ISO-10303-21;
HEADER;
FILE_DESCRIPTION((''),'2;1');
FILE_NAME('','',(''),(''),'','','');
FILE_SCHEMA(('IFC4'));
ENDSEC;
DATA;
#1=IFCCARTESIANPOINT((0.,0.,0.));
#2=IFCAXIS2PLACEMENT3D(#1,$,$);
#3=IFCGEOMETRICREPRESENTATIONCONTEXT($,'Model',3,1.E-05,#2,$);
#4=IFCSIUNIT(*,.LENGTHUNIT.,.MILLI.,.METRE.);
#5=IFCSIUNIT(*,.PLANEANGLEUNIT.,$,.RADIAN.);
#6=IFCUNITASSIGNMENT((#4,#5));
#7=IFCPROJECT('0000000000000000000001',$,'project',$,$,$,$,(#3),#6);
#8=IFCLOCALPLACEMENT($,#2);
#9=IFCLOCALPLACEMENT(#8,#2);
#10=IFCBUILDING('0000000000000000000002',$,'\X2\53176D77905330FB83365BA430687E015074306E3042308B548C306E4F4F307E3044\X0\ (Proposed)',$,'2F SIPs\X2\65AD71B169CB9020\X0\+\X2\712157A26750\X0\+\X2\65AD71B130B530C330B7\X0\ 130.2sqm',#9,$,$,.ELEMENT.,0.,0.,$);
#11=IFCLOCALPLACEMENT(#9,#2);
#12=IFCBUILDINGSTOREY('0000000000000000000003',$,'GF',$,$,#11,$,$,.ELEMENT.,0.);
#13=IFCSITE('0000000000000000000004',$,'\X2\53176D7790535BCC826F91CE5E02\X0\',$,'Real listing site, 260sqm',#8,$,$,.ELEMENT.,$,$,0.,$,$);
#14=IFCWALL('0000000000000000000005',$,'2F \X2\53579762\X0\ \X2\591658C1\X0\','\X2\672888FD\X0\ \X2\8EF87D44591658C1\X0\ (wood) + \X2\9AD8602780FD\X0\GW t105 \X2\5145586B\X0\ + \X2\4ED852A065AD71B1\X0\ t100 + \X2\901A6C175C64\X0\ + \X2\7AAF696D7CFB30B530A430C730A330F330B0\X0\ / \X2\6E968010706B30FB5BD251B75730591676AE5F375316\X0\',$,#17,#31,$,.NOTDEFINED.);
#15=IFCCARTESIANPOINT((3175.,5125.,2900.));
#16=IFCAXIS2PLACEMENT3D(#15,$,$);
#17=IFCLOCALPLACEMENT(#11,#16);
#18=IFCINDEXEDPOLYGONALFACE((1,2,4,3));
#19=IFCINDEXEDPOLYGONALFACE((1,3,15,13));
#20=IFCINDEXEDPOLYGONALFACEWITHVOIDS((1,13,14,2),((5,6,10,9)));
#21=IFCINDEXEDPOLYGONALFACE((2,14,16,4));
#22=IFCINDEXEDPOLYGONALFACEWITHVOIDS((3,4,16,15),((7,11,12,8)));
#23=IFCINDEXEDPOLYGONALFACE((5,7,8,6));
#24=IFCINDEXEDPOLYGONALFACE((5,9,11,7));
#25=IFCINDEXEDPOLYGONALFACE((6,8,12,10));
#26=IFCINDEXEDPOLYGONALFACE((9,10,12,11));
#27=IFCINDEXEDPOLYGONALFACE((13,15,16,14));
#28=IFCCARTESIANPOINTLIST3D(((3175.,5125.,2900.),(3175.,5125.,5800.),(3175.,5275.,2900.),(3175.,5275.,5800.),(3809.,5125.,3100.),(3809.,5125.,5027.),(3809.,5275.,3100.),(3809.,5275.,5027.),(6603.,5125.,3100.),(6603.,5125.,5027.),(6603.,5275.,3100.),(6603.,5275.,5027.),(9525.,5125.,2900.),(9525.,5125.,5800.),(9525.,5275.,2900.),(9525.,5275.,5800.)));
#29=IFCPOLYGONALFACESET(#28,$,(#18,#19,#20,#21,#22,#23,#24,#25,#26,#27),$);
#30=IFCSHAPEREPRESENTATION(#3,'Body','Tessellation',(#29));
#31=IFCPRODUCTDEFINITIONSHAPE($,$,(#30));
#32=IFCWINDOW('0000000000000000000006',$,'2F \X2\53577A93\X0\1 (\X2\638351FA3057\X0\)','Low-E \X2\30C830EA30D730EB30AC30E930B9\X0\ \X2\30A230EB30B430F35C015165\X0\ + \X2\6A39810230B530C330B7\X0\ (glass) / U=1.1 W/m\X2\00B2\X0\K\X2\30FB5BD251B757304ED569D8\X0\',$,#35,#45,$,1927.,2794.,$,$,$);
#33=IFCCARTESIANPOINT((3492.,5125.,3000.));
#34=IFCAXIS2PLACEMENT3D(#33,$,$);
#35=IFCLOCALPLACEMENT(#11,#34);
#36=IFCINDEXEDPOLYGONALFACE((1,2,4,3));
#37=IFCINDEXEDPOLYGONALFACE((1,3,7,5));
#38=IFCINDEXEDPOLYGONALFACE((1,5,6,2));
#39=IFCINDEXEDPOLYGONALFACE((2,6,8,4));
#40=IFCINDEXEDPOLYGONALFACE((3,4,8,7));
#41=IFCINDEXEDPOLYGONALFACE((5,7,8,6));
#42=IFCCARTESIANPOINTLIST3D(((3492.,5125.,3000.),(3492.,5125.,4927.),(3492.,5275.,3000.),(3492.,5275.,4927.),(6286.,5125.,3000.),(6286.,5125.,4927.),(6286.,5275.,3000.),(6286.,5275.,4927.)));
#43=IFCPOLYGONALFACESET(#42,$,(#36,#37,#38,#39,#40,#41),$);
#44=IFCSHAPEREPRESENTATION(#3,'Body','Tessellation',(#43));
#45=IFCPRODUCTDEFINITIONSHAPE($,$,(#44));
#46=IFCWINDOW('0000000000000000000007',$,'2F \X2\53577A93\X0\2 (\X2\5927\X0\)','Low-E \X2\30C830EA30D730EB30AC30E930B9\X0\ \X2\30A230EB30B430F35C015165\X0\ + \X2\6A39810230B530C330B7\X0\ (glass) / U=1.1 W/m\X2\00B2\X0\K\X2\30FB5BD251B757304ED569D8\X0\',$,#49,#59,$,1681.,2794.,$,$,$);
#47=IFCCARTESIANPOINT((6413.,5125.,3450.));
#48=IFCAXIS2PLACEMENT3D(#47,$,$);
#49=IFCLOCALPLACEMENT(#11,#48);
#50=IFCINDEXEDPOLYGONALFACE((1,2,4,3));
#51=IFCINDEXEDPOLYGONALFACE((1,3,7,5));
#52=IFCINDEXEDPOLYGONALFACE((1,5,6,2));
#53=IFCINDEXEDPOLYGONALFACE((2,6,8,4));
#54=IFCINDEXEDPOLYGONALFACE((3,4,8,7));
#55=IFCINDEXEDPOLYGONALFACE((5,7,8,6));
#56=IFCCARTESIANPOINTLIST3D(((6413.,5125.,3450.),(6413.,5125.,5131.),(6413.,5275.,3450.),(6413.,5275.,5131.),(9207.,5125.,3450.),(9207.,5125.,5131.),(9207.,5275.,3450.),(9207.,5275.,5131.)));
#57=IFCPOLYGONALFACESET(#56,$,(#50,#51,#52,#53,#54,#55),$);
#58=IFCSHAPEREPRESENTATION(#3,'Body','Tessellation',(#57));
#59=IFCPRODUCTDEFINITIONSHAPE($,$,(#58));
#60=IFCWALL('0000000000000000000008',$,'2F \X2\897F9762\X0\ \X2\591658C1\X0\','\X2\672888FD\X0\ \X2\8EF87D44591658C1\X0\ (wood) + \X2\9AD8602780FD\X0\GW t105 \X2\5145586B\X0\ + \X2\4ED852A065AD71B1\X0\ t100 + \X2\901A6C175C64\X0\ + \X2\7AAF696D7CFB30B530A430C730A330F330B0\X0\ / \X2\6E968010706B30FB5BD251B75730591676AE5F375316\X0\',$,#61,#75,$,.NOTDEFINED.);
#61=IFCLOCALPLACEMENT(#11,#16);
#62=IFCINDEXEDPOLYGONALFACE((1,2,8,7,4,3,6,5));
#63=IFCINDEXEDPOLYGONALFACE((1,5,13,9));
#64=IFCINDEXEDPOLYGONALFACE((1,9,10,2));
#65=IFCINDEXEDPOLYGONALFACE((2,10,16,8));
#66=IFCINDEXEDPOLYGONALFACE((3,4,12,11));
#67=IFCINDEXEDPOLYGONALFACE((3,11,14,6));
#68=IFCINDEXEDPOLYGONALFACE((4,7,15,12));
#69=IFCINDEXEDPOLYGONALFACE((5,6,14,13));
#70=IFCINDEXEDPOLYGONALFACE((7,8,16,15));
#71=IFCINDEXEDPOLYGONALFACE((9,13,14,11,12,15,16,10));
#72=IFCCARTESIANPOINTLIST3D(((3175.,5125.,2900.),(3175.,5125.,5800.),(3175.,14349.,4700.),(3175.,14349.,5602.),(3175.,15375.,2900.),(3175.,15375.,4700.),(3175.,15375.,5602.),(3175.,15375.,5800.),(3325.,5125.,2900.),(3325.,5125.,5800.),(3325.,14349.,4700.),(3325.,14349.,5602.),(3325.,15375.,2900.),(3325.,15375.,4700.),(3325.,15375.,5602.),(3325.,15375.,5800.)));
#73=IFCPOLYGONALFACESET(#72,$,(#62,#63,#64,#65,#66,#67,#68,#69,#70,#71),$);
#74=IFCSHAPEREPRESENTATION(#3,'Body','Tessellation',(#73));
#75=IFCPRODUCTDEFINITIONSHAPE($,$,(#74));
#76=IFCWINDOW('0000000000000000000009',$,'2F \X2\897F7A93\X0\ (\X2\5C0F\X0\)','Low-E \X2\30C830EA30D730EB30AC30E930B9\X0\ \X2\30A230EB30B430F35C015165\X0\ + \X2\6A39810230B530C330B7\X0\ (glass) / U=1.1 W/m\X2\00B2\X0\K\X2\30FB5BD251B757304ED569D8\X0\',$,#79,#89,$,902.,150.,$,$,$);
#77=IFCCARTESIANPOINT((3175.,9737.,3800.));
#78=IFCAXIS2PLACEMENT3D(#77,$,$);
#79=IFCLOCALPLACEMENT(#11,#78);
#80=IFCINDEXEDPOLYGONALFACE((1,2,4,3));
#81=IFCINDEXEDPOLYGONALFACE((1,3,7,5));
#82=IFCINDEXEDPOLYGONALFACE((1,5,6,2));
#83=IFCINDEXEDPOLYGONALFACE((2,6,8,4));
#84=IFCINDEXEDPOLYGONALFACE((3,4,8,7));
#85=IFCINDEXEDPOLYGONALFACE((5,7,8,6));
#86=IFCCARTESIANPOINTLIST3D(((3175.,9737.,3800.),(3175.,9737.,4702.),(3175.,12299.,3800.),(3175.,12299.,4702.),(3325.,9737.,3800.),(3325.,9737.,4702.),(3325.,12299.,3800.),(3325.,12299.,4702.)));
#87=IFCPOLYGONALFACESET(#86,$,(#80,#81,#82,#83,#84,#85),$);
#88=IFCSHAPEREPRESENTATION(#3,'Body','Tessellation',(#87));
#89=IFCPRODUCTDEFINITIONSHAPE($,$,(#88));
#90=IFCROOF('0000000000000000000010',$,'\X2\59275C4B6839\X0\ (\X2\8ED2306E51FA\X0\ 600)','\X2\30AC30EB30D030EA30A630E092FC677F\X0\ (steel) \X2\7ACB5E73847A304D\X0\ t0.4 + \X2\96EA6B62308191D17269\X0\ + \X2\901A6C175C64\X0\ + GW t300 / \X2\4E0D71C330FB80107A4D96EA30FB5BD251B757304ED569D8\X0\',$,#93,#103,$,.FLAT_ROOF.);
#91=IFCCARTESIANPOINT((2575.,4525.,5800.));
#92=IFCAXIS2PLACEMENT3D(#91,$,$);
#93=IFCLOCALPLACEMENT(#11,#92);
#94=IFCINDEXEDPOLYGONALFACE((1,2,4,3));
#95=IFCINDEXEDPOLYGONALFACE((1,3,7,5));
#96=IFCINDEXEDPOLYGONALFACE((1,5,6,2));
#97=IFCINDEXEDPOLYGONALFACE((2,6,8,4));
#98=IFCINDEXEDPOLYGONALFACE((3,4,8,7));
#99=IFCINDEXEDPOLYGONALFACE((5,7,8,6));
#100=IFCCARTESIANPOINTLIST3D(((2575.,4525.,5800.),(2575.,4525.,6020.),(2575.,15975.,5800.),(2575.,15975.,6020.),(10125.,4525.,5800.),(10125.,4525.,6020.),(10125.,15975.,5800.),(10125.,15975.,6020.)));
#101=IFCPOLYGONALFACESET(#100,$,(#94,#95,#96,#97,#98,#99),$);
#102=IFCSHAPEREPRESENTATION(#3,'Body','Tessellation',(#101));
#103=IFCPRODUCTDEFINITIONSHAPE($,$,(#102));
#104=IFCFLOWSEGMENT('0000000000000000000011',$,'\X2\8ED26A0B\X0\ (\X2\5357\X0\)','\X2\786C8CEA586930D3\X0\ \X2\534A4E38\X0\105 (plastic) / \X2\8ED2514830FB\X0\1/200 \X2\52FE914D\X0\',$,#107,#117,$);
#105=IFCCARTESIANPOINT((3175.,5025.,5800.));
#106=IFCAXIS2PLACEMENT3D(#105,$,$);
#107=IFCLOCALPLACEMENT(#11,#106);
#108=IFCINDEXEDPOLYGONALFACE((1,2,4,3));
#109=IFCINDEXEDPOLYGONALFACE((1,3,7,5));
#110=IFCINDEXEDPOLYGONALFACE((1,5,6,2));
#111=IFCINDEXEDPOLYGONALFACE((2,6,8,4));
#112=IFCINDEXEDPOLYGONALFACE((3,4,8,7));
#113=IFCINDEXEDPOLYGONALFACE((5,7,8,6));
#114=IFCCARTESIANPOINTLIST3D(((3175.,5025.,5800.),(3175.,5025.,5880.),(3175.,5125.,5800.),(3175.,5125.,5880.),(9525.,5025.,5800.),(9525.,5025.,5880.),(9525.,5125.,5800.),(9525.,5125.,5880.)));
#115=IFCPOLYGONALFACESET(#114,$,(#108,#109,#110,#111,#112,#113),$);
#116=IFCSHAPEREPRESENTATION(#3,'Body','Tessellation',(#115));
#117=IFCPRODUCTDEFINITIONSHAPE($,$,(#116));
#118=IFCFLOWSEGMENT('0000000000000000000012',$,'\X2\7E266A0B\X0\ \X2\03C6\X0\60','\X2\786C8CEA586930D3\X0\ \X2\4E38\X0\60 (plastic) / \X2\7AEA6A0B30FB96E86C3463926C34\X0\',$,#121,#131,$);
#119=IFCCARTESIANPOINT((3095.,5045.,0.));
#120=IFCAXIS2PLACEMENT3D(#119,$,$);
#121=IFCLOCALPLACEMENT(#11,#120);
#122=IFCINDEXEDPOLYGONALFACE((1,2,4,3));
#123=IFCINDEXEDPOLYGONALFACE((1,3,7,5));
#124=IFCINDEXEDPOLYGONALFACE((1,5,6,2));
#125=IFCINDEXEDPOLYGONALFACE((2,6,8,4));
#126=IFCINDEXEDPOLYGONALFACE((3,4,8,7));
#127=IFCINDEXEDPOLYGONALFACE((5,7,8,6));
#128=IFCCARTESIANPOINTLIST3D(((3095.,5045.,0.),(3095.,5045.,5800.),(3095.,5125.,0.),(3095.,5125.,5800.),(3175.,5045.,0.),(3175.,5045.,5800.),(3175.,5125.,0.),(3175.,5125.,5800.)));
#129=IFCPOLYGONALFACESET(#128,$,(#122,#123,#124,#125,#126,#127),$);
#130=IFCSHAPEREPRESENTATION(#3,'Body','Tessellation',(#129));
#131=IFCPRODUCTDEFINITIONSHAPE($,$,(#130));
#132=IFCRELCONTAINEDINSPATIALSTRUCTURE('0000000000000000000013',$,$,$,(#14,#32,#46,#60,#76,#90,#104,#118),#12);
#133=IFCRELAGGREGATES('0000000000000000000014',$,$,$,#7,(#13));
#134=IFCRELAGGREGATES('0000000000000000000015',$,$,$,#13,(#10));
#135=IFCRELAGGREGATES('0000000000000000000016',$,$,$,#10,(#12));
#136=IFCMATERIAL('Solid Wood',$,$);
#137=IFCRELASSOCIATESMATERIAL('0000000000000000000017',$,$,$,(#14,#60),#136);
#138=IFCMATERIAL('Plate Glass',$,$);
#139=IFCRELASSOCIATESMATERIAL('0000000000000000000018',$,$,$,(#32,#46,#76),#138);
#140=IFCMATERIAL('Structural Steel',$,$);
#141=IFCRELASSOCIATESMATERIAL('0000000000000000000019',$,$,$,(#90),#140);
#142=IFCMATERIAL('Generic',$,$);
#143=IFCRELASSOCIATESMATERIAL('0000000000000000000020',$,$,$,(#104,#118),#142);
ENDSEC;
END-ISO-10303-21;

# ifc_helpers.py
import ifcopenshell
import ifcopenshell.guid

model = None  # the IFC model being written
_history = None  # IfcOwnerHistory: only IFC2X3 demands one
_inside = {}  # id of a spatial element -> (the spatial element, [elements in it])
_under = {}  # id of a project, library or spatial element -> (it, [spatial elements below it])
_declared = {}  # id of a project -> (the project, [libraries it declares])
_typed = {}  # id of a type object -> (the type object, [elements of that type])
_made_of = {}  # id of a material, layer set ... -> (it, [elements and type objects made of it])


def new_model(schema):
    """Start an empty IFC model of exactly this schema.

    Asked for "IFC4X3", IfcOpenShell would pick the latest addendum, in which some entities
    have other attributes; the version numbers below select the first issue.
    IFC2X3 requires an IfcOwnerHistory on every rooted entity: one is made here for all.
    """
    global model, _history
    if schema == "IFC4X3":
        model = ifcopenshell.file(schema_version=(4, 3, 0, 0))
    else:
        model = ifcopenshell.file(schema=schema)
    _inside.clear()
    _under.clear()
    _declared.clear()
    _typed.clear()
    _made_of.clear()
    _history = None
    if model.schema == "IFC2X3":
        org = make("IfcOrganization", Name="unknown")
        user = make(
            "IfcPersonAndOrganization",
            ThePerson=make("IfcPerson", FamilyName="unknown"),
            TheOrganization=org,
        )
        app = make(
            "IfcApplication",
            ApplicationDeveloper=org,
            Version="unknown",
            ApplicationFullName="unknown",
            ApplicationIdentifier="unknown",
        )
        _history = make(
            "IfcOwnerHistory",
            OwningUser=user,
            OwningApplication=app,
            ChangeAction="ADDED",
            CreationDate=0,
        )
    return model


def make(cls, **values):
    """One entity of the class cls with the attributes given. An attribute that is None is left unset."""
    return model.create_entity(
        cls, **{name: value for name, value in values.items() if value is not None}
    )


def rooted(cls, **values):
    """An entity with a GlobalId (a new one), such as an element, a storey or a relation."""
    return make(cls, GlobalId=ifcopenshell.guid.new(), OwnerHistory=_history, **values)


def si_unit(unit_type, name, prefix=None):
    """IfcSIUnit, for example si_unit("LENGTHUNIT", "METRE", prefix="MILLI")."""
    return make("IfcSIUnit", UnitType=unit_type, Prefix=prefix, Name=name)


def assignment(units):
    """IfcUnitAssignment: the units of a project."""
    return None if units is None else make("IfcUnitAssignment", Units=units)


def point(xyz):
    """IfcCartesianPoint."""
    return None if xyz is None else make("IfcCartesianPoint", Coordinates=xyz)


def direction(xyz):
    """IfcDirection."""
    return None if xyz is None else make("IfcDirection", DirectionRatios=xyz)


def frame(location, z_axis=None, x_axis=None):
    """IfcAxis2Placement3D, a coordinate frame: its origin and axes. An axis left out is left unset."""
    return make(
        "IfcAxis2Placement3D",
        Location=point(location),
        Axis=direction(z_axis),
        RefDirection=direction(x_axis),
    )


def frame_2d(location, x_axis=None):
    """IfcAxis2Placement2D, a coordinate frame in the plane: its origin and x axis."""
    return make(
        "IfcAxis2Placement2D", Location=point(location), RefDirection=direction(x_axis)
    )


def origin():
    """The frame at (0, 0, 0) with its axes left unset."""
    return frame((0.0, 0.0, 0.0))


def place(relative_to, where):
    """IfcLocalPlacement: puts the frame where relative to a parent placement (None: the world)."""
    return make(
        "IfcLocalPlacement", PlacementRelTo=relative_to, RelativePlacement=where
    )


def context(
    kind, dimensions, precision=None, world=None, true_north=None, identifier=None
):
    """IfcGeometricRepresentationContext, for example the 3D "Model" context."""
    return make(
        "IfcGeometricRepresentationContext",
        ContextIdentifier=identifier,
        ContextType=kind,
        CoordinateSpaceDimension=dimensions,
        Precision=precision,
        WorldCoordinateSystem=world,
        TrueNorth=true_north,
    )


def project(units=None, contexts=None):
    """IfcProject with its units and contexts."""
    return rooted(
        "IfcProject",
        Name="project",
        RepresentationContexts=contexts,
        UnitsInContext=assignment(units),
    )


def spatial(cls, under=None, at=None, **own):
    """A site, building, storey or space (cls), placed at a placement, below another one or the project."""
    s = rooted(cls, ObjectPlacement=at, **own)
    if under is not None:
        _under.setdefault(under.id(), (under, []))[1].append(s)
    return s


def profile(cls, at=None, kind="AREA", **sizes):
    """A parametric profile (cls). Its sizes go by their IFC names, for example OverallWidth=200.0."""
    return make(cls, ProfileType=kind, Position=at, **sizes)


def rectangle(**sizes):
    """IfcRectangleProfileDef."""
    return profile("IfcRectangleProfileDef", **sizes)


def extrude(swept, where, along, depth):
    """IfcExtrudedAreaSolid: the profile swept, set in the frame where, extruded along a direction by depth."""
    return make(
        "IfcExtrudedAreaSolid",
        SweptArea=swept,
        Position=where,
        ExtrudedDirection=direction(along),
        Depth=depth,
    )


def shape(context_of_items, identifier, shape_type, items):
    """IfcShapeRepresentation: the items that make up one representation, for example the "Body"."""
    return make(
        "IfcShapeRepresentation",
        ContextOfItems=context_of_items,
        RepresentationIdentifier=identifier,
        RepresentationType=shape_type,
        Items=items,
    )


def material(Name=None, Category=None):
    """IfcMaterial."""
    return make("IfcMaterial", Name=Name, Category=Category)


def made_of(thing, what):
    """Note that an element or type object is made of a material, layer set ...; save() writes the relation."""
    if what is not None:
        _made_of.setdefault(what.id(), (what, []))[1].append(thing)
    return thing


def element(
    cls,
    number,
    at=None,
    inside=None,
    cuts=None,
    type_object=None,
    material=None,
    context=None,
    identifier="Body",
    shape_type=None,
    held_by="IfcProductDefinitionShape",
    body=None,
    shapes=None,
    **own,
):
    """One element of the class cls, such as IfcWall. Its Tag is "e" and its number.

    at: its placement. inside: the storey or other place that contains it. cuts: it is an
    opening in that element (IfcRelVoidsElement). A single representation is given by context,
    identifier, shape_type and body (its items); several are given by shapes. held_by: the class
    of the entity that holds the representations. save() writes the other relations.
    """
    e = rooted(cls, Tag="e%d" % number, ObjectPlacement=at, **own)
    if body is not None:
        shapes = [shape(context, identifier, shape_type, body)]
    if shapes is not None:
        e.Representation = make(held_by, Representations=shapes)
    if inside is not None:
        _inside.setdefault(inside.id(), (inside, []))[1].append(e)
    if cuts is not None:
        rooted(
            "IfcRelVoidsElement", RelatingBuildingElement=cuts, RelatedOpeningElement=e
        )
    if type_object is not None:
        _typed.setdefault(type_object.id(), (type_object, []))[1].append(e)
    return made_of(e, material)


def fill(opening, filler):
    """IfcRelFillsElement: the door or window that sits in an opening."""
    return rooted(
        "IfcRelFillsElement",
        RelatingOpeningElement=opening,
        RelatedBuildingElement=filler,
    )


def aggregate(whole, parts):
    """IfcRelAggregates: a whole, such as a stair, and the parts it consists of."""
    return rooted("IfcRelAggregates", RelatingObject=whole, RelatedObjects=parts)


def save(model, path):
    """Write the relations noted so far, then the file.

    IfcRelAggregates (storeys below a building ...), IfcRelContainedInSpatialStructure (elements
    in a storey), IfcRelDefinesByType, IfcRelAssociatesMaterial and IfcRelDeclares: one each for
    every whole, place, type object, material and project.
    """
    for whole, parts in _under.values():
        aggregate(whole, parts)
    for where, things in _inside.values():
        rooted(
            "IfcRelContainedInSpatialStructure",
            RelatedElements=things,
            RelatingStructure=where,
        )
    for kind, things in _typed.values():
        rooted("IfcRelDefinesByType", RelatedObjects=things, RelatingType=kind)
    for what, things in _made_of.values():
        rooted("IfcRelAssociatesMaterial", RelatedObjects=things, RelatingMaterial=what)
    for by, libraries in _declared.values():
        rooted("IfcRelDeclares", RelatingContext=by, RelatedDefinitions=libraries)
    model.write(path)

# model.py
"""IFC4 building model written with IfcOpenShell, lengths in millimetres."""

from ifc_helpers import new_model, si_unit, frame, frame_2d, origin, place, context, project, spatial, rectangle, extrude, material, element, fill, save


model = new_model("IFC4")

# Units and contexts
model_context = context("Model", 3, precision=1e-05, world=origin())
ifc_project = project(units=[si_unit("LENGTHUNIT", "METRE", prefix="MILLI"), si_unit("PLANEANGLEUNIT", "RADIAN")], contexts=[model_context])

# Site, building, storey
site_placement = place(None, origin())
site = spatial("IfcSite", under=ifc_project, at=site_placement, Name="北海道富良野市", ObjectType="Real listing site, 260sqm", CompositionType="ELEMENT", RefElevation=0.0)
building_placement = place(site_placement, origin())
building = spatial("IfcBuilding", under=site, at=building_placement, Name="北海道・茶室と縁側のある和の住まい (Proposed)", ObjectType="2F SIPs断熱構造+無垢材+断熱サッシ 130.2sqm", CompositionType="ELEMENT", ElevationOfRefHeight=0.0, ElevationOfTerrain=0.0)
storey_placement = place(building_placement, origin())
storey = spatial("IfcBuildingStorey", under=building, at=storey_placement, Name="GF", CompositionType="ELEMENT", Elevation=0.0)

# Shared definitions
ifc_material_1 = material(Name="Solid Wood")

# Shared definitions
ifc_material_2 = material(Name="Plate Glass")

# Wall, openings, windows
wall_1_placement = place(storey_placement, frame((3175.0, 5125.0, 2900.0)))
wall_1 = element("IfcWall", 1, at=wall_1_placement, inside=storey, material=ifc_material_1, Name="2F 南面 外壁", Description="木製 軸組外壁 (wood) + 高性能GW t105 充填 + 付加断熱 t100 + 通気層 + 窯業系サイディング / 準耐火・寒冷地外皮強化", PredefinedType="NOTDEFINED", context=model_context, shape_type="SweptSolid", body=[
    extrude(rectangle(XDim=6350.0, YDim=150.0, at=frame_2d((3175.0, 75.0))), frame((3175.0, 5125.0, 2900.0)), (0.0, 0.0, 1.0), 2900.0),
])
opening_1_placement = place(storey_placement, frame((3492.0, 5125.0, 3000.0)))
opening_1 = element("IfcOpeningElement", 2, at=opening_1_placement, cuts=wall_1, PredefinedType="NOTDEFINED", context=model_context, shape_type="SweptSolid", body=[
    extrude(rectangle(XDim=2794.0, YDim=150.0, at=frame_2d((1397.0, 75.0))), frame((3492.0, 5125.0, 3000.0)), (0.0, 0.0, 1.0), 1927.0),
])
opening_2_placement = place(storey_placement, frame((6413.0, 5125.0, 3450.0)))
opening_2 = element("IfcOpeningElement", 3, at=opening_2_placement, cuts=wall_1, PredefinedType="NOTDEFINED", context=model_context, shape_type="SweptSolid", body=[
    extrude(rectangle(XDim=2794.0, YDim=150.0, at=frame_2d((1397.0, 75.0))), frame((6413.0, 5125.0, 3450.0)), (0.0, 0.0, 1.0), 1681.0),
])
window_1_placement = place(storey_placement, frame((3492.0, 5125.0, 3000.0)))
window_1 = element("IfcWindow", 4, at=window_1_placement, inside=storey, material=ifc_material_2, Name="2F 南窓1 (掃出し)", Description="Low-E トリプルガラス アルゴン封入 + 樹脂サッシ (glass) / U=1.1 W/m²K・寒冷地仕様", OverallHeight=1927.0, OverallWidth=2794.0, context=model_context, shape_type="SweptSolid", body=[
    extrude(rectangle(XDim=2794.0, YDim=150.0, at=frame_2d((1397.0, 75.0))), frame((3492.0, 5125.0, 3000.0)), (0.0, 0.0, 1.0), 1927.0),
])
fill(opening_1, window_1)
window_2_placement = place(storey_placement, frame((6413.0, 5125.0, 3450.0)))
window_2 = element("IfcWindow", 5, at=window_2_placement, inside=storey, material=ifc_material_2, Name="2F 南窓2 (大)", Description="Low-E トリプルガラス アルゴン封入 + 樹脂サッシ (glass) / U=1.1 W/m²K・寒冷地仕様", OverallHeight=1681.0, OverallWidth=2794.0, context=model_context, shape_type="SweptSolid", body=[
    extrude(rectangle(XDim=2794.0, YDim=150.0, at=frame_2d((1397.0, 75.0))), frame((6413.0, 5125.0, 3450.0)), (0.0, 0.0, 1.0), 1681.0),
])
fill(opening_2, window_2)

# Wall, opening, window
wall_2_placement = place(storey_placement, frame((3175.0, 5125.0, 2900.0)))
wall_2 = element("IfcWall", 6, at=wall_2_placement, inside=storey, material=ifc_material_1, Name="2F 西面 外壁", Description="木製 軸組外壁 (wood) + 高性能GW t105 充填 + 付加断熱 t100 + 通気層 + 窯業系サイディング / 準耐火・寒冷地外皮強化", PredefinedType="NOTDEFINED", context=model_context, shape_type="SweptSolid", body=[
    extrude(rectangle(XDim=150.0, YDim=10250.0, at=frame_2d((75.0, 5125.0))), frame((3175.0, 5125.0, 2900.0)), (0.0, 0.0, 1.0), 2900.0),
])
opening_3_placement = place(storey_placement, frame((3175.0, 9737.0, 3800.0)))
opening_3 = element("IfcOpeningElement", 7, at=opening_3_placement, cuts=wall_2, PredefinedType="NOTDEFINED", context=model_context, shape_type="SweptSolid", body=[
    extrude(rectangle(XDim=150.0, YDim=2562.0, at=frame_2d((75.0, 1281.0))), frame((3175.0, 9737.0, 3800.0)), (0.0, 0.0, 1.0), 902.0),
])
window_3_placement = place(storey_placement, frame((3175.0, 9737.0, 3800.0)))
window_3 = element("IfcWindow", 8, at=window_3_placement, inside=storey, material=ifc_material_2, Name="2F 西窓 (小)", Description="Low-E トリプルガラス アルゴン封入 + 樹脂サッシ (glass) / U=1.1 W/m²K・寒冷地仕様", OverallHeight=902.0, OverallWidth=150.0, context=model_context, shape_type="SweptSolid", body=[
    extrude(rectangle(XDim=150.0, YDim=2562.0, at=frame_2d((75.0, 1281.0))), frame((3175.0, 9737.0, 3800.0)), (0.0, 0.0, 1.0), 902.0),
])
fill(opening_3, window_3)

# Roof
ifc_material_3 = material(Name="Structural Steel")
roof_placement = place(storey_placement, frame((2575.0, 4525.0, 5800.0)))
element("IfcRoof", 9, at=roof_placement, inside=storey, material=ifc_material_3, Name="大屋根 (軒の出 600)", Description="ガルバリウム鋼板 (steel) 立平葺き t0.4 + 雪止め金物 + 通気層 + GW t300 / 不燃・耐積雪・寒冷地仕様", PredefinedType="FLAT_ROOF", context=model_context, shape_type="SweptSolid", body=[
    extrude(rectangle(XDim=7550.0, YDim=11450.0, at=frame_2d((3775.0, 5725.0))), frame((2575.0, 4525.0, 5800.0)), (0.0, 0.0, 1.0), 220.0),
])

# Flow segments
ifc_material_4 = material(Name="Generic")
flow_segment_1_placement = place(storey_placement, frame((3175.0, 5025.0, 5800.0)))
element("IfcFlowSegment", 10, at=flow_segment_1_placement, inside=storey, material=ifc_material_4, Name="軒樋 (南)", Description="硬質塩ビ 半丸105 (plastic) / 軒先・1/200 勾配", context=model_context, shape_type="SweptSolid", body=[
    extrude(rectangle(XDim=6350.0, YDim=100.0, at=frame_2d((3175.0, 50.0))), frame((3175.0, 5025.0, 5800.0)), (0.0, 0.0, 1.0), 80.0),
])
flow_segment_2_placement = place(storey_placement, frame((3095.0, 5045.0, 0.0)))
element("IfcFlowSegment", 11, at=flow_segment_2_placement, inside=storey, material=ifc_material_4, Name="縦樋 φ60", Description="硬質塩ビ 丸60 (plastic) / 竪樋・雨水排水", context=model_context, shape_type="SweptSolid", body=[
    extrude(rectangle(XDim=80.0, YDim=80.0, at=frame_2d((40.0, 40.0))), frame((3095.0, 5045.0, 0.0)), (0.0, 0.0, 1.0), 5800.0),
])

save(model, "model.ifc")
